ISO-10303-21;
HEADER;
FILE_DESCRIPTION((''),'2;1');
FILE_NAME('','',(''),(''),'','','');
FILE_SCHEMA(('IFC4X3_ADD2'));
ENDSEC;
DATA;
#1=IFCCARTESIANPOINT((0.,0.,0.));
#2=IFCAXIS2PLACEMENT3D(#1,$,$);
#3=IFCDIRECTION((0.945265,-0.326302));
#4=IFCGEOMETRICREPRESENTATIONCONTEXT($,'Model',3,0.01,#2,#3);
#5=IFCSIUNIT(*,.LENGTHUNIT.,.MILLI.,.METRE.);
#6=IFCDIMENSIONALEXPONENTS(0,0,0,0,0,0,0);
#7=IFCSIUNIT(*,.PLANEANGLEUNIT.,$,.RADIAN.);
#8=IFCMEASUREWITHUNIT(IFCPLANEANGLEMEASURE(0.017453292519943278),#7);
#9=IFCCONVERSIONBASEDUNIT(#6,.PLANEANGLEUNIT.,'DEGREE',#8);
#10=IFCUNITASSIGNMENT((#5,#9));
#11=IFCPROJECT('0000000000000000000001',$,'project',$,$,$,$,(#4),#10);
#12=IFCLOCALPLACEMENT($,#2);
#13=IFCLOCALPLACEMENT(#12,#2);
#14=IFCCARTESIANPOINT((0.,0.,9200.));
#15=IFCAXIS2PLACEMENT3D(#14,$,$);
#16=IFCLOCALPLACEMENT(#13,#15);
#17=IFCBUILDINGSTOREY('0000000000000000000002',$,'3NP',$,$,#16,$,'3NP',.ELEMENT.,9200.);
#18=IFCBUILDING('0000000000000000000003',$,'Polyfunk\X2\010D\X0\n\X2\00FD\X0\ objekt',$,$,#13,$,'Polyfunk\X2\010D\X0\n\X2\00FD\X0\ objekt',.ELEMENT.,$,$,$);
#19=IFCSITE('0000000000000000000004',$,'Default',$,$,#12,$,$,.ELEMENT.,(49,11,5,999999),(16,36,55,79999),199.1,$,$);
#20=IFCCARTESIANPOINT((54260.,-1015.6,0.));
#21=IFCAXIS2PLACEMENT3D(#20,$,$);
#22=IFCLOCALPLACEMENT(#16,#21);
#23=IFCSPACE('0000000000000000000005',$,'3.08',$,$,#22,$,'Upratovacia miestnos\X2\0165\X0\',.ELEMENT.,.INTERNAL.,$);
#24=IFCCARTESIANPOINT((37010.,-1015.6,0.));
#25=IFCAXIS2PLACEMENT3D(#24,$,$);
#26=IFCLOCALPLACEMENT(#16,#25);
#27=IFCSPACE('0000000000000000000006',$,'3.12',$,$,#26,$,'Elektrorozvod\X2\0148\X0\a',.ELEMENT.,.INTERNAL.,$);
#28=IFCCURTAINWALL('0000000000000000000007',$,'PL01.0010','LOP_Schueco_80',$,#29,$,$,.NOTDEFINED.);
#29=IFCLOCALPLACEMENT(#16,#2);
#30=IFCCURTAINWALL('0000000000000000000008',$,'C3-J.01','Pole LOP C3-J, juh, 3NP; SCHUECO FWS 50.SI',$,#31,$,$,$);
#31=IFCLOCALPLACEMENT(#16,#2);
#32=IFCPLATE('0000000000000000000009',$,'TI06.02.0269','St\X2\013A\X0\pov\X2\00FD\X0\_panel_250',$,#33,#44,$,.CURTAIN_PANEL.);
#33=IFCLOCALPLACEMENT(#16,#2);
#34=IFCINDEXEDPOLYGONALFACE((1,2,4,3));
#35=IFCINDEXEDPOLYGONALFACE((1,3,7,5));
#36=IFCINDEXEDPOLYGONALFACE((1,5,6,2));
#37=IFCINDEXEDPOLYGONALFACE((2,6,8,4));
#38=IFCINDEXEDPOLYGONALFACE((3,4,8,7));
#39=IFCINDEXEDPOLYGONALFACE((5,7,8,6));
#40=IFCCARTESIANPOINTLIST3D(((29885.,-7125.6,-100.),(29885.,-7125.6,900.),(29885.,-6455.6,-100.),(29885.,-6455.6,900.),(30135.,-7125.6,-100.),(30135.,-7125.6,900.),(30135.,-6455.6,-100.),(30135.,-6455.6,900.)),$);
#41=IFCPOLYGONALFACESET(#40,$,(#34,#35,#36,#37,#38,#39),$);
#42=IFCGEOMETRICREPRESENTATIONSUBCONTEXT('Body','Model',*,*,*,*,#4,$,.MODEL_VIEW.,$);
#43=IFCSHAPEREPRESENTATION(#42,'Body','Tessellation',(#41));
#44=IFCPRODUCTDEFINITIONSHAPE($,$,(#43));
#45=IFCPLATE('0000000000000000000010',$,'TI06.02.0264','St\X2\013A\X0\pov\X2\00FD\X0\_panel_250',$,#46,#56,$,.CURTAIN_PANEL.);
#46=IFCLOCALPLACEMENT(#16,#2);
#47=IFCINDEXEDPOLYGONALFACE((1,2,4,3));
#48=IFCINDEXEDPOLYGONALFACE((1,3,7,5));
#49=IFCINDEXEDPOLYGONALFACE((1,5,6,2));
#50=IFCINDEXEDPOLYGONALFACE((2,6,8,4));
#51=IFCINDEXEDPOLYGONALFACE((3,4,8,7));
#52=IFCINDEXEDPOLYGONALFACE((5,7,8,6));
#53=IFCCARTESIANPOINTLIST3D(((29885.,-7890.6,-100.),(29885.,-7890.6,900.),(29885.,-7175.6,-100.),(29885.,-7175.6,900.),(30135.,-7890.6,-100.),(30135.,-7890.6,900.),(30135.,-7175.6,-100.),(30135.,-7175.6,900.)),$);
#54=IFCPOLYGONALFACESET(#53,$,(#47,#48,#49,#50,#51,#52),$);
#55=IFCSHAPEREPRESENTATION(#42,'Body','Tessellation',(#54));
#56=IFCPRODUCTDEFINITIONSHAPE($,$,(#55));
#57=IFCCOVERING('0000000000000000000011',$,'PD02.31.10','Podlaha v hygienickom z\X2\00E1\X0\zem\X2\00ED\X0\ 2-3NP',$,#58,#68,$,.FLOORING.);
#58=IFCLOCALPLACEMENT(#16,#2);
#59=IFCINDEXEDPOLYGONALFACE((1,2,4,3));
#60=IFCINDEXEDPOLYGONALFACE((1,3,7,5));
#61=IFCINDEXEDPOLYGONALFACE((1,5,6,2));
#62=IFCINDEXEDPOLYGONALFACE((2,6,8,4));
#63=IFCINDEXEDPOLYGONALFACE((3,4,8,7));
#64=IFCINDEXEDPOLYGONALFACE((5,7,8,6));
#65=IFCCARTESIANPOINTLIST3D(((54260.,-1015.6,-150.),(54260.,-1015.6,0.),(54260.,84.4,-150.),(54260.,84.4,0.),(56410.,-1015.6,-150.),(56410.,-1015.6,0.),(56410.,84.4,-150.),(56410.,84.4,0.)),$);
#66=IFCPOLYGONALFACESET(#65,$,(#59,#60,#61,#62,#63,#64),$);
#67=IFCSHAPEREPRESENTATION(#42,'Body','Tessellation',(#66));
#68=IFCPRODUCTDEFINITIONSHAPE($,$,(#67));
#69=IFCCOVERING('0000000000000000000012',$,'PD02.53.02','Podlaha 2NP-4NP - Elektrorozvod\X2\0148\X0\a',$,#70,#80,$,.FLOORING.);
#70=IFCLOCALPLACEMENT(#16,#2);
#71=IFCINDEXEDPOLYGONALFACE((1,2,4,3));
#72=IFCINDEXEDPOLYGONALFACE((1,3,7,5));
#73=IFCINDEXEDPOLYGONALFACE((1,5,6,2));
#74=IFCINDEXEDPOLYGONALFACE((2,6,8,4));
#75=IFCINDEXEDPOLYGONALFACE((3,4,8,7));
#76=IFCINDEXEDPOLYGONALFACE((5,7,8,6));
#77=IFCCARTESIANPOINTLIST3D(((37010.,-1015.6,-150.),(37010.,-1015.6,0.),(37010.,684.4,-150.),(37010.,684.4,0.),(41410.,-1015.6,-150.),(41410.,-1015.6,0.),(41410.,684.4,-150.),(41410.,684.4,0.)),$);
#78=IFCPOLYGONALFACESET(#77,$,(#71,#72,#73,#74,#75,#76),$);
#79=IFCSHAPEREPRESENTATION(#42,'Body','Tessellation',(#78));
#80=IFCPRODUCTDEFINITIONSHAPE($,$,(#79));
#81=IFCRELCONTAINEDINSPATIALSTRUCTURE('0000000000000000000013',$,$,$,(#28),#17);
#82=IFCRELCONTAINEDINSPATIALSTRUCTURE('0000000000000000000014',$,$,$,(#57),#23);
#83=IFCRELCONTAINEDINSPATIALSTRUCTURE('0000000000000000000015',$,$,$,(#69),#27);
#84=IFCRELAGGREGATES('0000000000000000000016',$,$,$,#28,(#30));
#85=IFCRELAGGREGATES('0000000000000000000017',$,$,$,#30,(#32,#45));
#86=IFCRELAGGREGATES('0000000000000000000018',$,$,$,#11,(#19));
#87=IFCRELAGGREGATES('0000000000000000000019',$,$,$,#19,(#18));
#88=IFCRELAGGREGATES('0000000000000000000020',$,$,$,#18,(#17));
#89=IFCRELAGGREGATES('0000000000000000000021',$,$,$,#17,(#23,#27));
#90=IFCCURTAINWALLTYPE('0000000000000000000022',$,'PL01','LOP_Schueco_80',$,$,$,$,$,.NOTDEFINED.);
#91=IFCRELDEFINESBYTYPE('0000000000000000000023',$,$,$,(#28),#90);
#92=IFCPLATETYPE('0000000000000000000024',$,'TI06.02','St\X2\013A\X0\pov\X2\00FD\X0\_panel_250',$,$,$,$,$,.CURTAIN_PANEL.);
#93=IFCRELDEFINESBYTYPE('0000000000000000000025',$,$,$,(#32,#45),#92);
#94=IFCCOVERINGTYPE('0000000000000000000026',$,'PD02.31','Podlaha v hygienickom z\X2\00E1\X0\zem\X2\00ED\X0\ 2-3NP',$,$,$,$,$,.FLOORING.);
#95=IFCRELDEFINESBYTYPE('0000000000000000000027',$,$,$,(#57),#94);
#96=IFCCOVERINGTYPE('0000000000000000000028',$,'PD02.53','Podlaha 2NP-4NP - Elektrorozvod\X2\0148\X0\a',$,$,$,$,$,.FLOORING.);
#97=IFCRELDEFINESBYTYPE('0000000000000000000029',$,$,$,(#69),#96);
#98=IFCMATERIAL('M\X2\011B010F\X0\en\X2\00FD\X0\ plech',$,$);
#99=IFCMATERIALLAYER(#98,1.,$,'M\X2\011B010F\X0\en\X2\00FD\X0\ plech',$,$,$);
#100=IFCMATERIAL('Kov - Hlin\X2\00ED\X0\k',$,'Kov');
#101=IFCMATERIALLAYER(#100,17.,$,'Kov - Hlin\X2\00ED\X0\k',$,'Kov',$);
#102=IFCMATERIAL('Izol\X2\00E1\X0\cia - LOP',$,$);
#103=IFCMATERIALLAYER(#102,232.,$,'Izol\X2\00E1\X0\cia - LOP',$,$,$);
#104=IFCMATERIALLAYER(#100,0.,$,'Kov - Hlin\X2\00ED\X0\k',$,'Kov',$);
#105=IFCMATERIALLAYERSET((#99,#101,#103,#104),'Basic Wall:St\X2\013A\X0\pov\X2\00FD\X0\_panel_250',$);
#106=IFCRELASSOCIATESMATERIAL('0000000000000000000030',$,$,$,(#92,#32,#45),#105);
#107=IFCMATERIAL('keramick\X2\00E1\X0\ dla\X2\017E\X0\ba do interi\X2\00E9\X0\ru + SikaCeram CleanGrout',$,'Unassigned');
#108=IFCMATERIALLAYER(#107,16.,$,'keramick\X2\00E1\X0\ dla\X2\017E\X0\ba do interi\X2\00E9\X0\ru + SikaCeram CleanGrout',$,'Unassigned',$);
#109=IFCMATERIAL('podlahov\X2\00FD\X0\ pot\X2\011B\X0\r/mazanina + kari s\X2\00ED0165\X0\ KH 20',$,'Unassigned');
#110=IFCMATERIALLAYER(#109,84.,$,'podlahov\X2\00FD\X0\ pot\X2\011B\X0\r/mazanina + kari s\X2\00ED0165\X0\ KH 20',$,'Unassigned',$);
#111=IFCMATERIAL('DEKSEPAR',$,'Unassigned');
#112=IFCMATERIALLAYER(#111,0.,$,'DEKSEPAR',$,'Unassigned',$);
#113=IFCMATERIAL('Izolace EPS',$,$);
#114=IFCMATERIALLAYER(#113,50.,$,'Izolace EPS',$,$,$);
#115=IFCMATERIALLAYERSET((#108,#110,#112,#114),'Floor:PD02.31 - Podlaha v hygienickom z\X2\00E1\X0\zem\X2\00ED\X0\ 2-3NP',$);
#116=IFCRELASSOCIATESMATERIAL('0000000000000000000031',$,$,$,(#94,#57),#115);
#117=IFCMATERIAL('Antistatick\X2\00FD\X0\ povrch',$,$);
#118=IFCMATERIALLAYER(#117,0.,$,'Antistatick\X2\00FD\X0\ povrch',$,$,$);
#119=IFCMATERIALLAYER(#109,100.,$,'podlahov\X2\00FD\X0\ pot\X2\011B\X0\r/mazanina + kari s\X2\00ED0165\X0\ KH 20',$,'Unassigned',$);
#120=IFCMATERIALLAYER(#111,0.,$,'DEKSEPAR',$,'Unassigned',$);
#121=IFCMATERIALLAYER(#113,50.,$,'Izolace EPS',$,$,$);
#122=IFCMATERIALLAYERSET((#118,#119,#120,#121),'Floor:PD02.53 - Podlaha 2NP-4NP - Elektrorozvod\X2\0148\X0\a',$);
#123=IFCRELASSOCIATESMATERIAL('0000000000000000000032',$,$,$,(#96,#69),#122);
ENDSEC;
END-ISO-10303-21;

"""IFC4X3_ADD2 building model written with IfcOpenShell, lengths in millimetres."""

from ifc_helpers import new_model, entity, si_unit, converted_unit, direction, frame, frame_2d, origin, place, context, subcontext, project, spatial, rectangle, extrude, material, layer, layer_set, layer_usage, type_object, element, aggregate, save


model = new_model("IFC4X3_ADD2")

# Units and contexts
model_context = context("Model", 3, precision=0.01, world=origin(), true_north=direction((0.945265, -0.326302)))
body_context = subcontext(model_context, "Body", "Model", "MODEL_VIEW")
ifc_project = project(units=[si_unit("LENGTHUNIT", "METRE", prefix="MILLI"), converted_unit("PLANEANGLEUNIT", "DEGREE", entity("IfcPlaneAngleMeasure", 0.017453292519943278), si_unit("PLANEANGLEUNIT", "RADIAN"), dimensions=[0, 0, 0, 0, 0, 0, 0])], contexts=[model_context])

# Site, building, storey
site_placement = place(None, origin())
site = spatial("IfcSite", under=ifc_project, at=site_placement, Name="Default", CompositionType="ELEMENT", RefLatitude=(49, 11, 5, 999999), RefLongitude=(16, 36, 55, 79999), RefElevation=199.1)
building_placement = place(site_placement, origin())
building = spatial("IfcBuilding", under=site, at=building_placement, Name="Polyfunkčný objekt", LongName="Polyfunkčný objekt", CompositionType="ELEMENT")
storey_placement = place(building_placement, frame((0.0, 0.0, 9200.0)))
storey = spatial("IfcBuildingStorey", under=building, at=storey_placement, Name="3NP", LongName="3NP", CompositionType="ELEMENT", Elevation=9200.0)

# Shared definitions
curtain_wall_type = type_object("IfcCurtainWallType", Name="PL01", Description="LOP_Schueco_80", PredefinedType="NOTDEFINED")

# Curtain walls
curtain_wall_1_placement = place(storey_placement, frame((0.0, 0.0, -9200.0)))
curtain_wall_1 = element("IfcCurtainWall", 1, at=curtain_wall_1_placement, inside=storey, type_object=curtain_wall_type, Name="PL01.0010", Description="LOP_Schueco_80", PredefinedType="NOTDEFINED")
curtain_wall_2 = element("IfcCurtainWall", 2, Name="C3-J.01", Description="Pole LOP C3-J, juh, 3NP; SCHUECO FWS 50.SI")
aggregate(curtain_wall_1, [curtain_wall_2])

# Shared definitions
ifc_material_1 = material(Name="Měďený plech")
ifc_layer_1 = layer(ifc_material_1, 1.0, Name="Měďený plech")
ifc_material_2 = material(Name="Kov - Hliník", Category="Kov")
ifc_layer_2 = layer(ifc_material_2, 17.0, Name="Kov - Hliník", Category="Kov")
ifc_material_3 = material(Name="Izolácia - LOP")
ifc_layer_3 = layer(ifc_material_3, 232.0, Name="Izolácia - LOP")
ifc_layer_4 = layer(ifc_material_2, 0.0, Name="Kov - Hliník", Category="Kov")
ifc_layer_set_1 = layer_set([ifc_layer_1, ifc_layer_2, ifc_layer_3, ifc_layer_4], Name="Basic Wall:Stĺpový_panel_250")
plate_type = type_object("IfcPlateType", Name="TI06.02", Description="Stĺpový_panel_250", PredefinedType="CURTAIN_PANEL", material=ifc_layer_set_1)

# Plates
ifc_layer_usage_1 = layer_usage(ifc_layer_set_1, "AXIS2", "POSITIVE", -125.0)
plate_1_placement = place(storey_placement, frame((30010.0, -6455.6, -100.0), z_axis=(0.0, 0.0, 1.0), x_axis=(0.0, -1.0, 0.0)))
plate_1 = element("IfcPlate", 3, at=plate_1_placement, type_object=plate_type, material=ifc_layer_usage_1, Name="TI06.02.0269", Description="Stĺpový_panel_250", PredefinedType="CURTAIN_PANEL", context=body_context, shape_type="SweptSolid", body=[
    extrude(rectangle(XDim=250.0, YDim=670.0, at=frame_2d((0.0, 0.0), x_axis=(1.0, 0.0))), frame((335.0, 0.0, 0.0), z_axis=(0.0, 0.0, 1.0), x_axis=(0.0, 1.0, 0.0)), (0.0, 0.0, 1.0), 1000.0),
])
ifc_layer_usage_2 = layer_usage(ifc_layer_set_1, "AXIS2", "POSITIVE", -125.0)
plate_2_placement = place(storey_placement, frame((30010.0, -7175.6, -100.0), z_axis=(0.0, 0.0, 1.0), x_axis=(0.0, -1.0, 0.0)))
plate_2 = element("IfcPlate", 4, at=plate_2_placement, type_object=plate_type, material=ifc_layer_usage_2, Name="TI06.02.0264", Description="Stĺpový_panel_250", PredefinedType="CURTAIN_PANEL", context=body_context, shape_type="SweptSolid", body=[
    extrude(rectangle(XDim=250.0, YDim=715.0, at=frame_2d((0.0, 0.0), x_axis=(1.0, 0.0))), frame((357.5, 0.0, 0.0), z_axis=(0.0, 0.0, 1.0), x_axis=(0.0, 1.0, 0.0)), (0.0, 0.0, 1.0), 1000.0),
])
aggregate(curtain_wall_2, [plate_1, plate_2])

# Shared definitions
ifc_material_4 = material(Name="keramická dlažba do interiéru + SikaCeram CleanGrout", Category="Unassigned")
ifc_layer_5 = layer(ifc_material_4, 16.0, Name="keramická dlažba do interiéru + SikaCeram CleanGrout", Category="Unassigned")
ifc_material_5 = material(Name="podlahový potěr/mazanina + kari síť KH 20", Category="Unassigned")
ifc_layer_6 = layer(ifc_material_5, 84.0, Name="podlahový potěr/mazanina + kari síť KH 20", Category="Unassigned")
ifc_material_6 = material(Name="DEKSEPAR", Category="Unassigned")
ifc_layer_7 = layer(ifc_material_6, 0.0, Name="DEKSEPAR", Category="Unassigned")
ifc_material_7 = material(Name="Izolace EPS")
ifc_layer_8 = layer(ifc_material_7, 50.0, Name="Izolace EPS")
ifc_layer_set_2 = layer_set([ifc_layer_5, ifc_layer_6, ifc_layer_7, ifc_layer_8], Name="Floor:PD02.31 - Podlaha v hygienickom zázemí 2-3NP")
covering_type_1 = type_object("IfcCoveringType", Name="PD02.31", Description="Podlaha v hygienickom zázemí 2-3NP", PredefinedType="FLOORING", material=ifc_layer_set_2)

# Shared definitions
space_1_placement = place(storey_placement, frame((54260.0, -1015.6, 0.0)))
space_1 = spatial("IfcSpace", under=storey, at=space_1_placement, Name="3.08", LongName="Upratovacia miestnosť", CompositionType="ELEMENT", PredefinedType="INTERNAL")

# Covering
ifc_layer_usage_3 = layer_usage(ifc_layer_set_2, "AXIS3", "POSITIVE", 0.0)
covering_1_placement = place(storey_placement, origin())
element("IfcCovering", 5, at=covering_1_placement, inside=space_1, type_object=covering_type_1, material=ifc_layer_usage_3, Name="PD02.31.10", Description="Podlaha v hygienickom zázemí 2-3NP", PredefinedType="FLOORING", context=body_context, shape_type="SweptSolid", body=[
    extrude(rectangle(XDim=1100.0, YDim=2150.0, at=frame_2d((0.0, 0.0), x_axis=(1.0, 0.0))), frame((55335.0, -465.6, 0.0), z_axis=(0.0, 0.0, -1.0), x_axis=(0.0, 1.0, 0.0)), (0.0, 0.0, 1.0), 150.0),
])

# Shared definitions
space_2_placement = place(storey_placement, frame((37010.0, -1015.6, 0.0)))
space_2 = spatial("IfcSpace", under=storey, at=space_2_placement, Name="3.12", LongName="Elektrorozvodňa", CompositionType="ELEMENT", PredefinedType="INTERNAL")

# Covering
ifc_material_8 = material(Name="Antistatický povrch")
ifc_layer_9 = layer(ifc_material_8, 0.0, Name="Antistatický povrch")
ifc_layer_10 = layer(ifc_material_5, 100.0, Name="podlahový potěr/mazanina + kari síť KH 20", Category="Unassigned")
ifc_layer_11 = layer(ifc_material_6, 0.0, Name="DEKSEPAR", Category="Unassigned")
ifc_layer_12 = layer(ifc_material_7, 50.0, Name="Izolace EPS")
ifc_layer_set_3 = layer_set([ifc_layer_9, ifc_layer_10, ifc_layer_11, ifc_layer_12], Name="Floor:PD02.53 - Podlaha 2NP-4NP - Elektrorozvodňa")
ifc_layer_usage_4 = layer_usage(ifc_layer_set_3, "AXIS3", "POSITIVE", 0.0)
covering_type_2 = type_object("IfcCoveringType", Name="PD02.53", Description="Podlaha 2NP-4NP - Elektrorozvodňa", PredefinedType="FLOORING", material=ifc_layer_set_3)
covering_2_placement = place(storey_placement, origin())
element("IfcCovering", 6, at=covering_2_placement, inside=space_2, type_object=covering_type_2, material=ifc_layer_usage_4, Name="PD02.53.02", Description="Podlaha 2NP-4NP - Elektrorozvodňa", PredefinedType="FLOORING", context=body_context, shape_type="SweptSolid", body=[
    extrude(rectangle(XDim=1700.0, YDim=4400.0, at=frame_2d((0.0, 0.0), x_axis=(1.0, 0.0))), frame((39210.0, -165.6, 0.0), z_axis=(0.0, 0.0, -1.0), x_axis=(0.0, 1.0, 0.0)), (0.0, 0.0, 1.0), 150.0),
])

save(model, "model.ifc")
